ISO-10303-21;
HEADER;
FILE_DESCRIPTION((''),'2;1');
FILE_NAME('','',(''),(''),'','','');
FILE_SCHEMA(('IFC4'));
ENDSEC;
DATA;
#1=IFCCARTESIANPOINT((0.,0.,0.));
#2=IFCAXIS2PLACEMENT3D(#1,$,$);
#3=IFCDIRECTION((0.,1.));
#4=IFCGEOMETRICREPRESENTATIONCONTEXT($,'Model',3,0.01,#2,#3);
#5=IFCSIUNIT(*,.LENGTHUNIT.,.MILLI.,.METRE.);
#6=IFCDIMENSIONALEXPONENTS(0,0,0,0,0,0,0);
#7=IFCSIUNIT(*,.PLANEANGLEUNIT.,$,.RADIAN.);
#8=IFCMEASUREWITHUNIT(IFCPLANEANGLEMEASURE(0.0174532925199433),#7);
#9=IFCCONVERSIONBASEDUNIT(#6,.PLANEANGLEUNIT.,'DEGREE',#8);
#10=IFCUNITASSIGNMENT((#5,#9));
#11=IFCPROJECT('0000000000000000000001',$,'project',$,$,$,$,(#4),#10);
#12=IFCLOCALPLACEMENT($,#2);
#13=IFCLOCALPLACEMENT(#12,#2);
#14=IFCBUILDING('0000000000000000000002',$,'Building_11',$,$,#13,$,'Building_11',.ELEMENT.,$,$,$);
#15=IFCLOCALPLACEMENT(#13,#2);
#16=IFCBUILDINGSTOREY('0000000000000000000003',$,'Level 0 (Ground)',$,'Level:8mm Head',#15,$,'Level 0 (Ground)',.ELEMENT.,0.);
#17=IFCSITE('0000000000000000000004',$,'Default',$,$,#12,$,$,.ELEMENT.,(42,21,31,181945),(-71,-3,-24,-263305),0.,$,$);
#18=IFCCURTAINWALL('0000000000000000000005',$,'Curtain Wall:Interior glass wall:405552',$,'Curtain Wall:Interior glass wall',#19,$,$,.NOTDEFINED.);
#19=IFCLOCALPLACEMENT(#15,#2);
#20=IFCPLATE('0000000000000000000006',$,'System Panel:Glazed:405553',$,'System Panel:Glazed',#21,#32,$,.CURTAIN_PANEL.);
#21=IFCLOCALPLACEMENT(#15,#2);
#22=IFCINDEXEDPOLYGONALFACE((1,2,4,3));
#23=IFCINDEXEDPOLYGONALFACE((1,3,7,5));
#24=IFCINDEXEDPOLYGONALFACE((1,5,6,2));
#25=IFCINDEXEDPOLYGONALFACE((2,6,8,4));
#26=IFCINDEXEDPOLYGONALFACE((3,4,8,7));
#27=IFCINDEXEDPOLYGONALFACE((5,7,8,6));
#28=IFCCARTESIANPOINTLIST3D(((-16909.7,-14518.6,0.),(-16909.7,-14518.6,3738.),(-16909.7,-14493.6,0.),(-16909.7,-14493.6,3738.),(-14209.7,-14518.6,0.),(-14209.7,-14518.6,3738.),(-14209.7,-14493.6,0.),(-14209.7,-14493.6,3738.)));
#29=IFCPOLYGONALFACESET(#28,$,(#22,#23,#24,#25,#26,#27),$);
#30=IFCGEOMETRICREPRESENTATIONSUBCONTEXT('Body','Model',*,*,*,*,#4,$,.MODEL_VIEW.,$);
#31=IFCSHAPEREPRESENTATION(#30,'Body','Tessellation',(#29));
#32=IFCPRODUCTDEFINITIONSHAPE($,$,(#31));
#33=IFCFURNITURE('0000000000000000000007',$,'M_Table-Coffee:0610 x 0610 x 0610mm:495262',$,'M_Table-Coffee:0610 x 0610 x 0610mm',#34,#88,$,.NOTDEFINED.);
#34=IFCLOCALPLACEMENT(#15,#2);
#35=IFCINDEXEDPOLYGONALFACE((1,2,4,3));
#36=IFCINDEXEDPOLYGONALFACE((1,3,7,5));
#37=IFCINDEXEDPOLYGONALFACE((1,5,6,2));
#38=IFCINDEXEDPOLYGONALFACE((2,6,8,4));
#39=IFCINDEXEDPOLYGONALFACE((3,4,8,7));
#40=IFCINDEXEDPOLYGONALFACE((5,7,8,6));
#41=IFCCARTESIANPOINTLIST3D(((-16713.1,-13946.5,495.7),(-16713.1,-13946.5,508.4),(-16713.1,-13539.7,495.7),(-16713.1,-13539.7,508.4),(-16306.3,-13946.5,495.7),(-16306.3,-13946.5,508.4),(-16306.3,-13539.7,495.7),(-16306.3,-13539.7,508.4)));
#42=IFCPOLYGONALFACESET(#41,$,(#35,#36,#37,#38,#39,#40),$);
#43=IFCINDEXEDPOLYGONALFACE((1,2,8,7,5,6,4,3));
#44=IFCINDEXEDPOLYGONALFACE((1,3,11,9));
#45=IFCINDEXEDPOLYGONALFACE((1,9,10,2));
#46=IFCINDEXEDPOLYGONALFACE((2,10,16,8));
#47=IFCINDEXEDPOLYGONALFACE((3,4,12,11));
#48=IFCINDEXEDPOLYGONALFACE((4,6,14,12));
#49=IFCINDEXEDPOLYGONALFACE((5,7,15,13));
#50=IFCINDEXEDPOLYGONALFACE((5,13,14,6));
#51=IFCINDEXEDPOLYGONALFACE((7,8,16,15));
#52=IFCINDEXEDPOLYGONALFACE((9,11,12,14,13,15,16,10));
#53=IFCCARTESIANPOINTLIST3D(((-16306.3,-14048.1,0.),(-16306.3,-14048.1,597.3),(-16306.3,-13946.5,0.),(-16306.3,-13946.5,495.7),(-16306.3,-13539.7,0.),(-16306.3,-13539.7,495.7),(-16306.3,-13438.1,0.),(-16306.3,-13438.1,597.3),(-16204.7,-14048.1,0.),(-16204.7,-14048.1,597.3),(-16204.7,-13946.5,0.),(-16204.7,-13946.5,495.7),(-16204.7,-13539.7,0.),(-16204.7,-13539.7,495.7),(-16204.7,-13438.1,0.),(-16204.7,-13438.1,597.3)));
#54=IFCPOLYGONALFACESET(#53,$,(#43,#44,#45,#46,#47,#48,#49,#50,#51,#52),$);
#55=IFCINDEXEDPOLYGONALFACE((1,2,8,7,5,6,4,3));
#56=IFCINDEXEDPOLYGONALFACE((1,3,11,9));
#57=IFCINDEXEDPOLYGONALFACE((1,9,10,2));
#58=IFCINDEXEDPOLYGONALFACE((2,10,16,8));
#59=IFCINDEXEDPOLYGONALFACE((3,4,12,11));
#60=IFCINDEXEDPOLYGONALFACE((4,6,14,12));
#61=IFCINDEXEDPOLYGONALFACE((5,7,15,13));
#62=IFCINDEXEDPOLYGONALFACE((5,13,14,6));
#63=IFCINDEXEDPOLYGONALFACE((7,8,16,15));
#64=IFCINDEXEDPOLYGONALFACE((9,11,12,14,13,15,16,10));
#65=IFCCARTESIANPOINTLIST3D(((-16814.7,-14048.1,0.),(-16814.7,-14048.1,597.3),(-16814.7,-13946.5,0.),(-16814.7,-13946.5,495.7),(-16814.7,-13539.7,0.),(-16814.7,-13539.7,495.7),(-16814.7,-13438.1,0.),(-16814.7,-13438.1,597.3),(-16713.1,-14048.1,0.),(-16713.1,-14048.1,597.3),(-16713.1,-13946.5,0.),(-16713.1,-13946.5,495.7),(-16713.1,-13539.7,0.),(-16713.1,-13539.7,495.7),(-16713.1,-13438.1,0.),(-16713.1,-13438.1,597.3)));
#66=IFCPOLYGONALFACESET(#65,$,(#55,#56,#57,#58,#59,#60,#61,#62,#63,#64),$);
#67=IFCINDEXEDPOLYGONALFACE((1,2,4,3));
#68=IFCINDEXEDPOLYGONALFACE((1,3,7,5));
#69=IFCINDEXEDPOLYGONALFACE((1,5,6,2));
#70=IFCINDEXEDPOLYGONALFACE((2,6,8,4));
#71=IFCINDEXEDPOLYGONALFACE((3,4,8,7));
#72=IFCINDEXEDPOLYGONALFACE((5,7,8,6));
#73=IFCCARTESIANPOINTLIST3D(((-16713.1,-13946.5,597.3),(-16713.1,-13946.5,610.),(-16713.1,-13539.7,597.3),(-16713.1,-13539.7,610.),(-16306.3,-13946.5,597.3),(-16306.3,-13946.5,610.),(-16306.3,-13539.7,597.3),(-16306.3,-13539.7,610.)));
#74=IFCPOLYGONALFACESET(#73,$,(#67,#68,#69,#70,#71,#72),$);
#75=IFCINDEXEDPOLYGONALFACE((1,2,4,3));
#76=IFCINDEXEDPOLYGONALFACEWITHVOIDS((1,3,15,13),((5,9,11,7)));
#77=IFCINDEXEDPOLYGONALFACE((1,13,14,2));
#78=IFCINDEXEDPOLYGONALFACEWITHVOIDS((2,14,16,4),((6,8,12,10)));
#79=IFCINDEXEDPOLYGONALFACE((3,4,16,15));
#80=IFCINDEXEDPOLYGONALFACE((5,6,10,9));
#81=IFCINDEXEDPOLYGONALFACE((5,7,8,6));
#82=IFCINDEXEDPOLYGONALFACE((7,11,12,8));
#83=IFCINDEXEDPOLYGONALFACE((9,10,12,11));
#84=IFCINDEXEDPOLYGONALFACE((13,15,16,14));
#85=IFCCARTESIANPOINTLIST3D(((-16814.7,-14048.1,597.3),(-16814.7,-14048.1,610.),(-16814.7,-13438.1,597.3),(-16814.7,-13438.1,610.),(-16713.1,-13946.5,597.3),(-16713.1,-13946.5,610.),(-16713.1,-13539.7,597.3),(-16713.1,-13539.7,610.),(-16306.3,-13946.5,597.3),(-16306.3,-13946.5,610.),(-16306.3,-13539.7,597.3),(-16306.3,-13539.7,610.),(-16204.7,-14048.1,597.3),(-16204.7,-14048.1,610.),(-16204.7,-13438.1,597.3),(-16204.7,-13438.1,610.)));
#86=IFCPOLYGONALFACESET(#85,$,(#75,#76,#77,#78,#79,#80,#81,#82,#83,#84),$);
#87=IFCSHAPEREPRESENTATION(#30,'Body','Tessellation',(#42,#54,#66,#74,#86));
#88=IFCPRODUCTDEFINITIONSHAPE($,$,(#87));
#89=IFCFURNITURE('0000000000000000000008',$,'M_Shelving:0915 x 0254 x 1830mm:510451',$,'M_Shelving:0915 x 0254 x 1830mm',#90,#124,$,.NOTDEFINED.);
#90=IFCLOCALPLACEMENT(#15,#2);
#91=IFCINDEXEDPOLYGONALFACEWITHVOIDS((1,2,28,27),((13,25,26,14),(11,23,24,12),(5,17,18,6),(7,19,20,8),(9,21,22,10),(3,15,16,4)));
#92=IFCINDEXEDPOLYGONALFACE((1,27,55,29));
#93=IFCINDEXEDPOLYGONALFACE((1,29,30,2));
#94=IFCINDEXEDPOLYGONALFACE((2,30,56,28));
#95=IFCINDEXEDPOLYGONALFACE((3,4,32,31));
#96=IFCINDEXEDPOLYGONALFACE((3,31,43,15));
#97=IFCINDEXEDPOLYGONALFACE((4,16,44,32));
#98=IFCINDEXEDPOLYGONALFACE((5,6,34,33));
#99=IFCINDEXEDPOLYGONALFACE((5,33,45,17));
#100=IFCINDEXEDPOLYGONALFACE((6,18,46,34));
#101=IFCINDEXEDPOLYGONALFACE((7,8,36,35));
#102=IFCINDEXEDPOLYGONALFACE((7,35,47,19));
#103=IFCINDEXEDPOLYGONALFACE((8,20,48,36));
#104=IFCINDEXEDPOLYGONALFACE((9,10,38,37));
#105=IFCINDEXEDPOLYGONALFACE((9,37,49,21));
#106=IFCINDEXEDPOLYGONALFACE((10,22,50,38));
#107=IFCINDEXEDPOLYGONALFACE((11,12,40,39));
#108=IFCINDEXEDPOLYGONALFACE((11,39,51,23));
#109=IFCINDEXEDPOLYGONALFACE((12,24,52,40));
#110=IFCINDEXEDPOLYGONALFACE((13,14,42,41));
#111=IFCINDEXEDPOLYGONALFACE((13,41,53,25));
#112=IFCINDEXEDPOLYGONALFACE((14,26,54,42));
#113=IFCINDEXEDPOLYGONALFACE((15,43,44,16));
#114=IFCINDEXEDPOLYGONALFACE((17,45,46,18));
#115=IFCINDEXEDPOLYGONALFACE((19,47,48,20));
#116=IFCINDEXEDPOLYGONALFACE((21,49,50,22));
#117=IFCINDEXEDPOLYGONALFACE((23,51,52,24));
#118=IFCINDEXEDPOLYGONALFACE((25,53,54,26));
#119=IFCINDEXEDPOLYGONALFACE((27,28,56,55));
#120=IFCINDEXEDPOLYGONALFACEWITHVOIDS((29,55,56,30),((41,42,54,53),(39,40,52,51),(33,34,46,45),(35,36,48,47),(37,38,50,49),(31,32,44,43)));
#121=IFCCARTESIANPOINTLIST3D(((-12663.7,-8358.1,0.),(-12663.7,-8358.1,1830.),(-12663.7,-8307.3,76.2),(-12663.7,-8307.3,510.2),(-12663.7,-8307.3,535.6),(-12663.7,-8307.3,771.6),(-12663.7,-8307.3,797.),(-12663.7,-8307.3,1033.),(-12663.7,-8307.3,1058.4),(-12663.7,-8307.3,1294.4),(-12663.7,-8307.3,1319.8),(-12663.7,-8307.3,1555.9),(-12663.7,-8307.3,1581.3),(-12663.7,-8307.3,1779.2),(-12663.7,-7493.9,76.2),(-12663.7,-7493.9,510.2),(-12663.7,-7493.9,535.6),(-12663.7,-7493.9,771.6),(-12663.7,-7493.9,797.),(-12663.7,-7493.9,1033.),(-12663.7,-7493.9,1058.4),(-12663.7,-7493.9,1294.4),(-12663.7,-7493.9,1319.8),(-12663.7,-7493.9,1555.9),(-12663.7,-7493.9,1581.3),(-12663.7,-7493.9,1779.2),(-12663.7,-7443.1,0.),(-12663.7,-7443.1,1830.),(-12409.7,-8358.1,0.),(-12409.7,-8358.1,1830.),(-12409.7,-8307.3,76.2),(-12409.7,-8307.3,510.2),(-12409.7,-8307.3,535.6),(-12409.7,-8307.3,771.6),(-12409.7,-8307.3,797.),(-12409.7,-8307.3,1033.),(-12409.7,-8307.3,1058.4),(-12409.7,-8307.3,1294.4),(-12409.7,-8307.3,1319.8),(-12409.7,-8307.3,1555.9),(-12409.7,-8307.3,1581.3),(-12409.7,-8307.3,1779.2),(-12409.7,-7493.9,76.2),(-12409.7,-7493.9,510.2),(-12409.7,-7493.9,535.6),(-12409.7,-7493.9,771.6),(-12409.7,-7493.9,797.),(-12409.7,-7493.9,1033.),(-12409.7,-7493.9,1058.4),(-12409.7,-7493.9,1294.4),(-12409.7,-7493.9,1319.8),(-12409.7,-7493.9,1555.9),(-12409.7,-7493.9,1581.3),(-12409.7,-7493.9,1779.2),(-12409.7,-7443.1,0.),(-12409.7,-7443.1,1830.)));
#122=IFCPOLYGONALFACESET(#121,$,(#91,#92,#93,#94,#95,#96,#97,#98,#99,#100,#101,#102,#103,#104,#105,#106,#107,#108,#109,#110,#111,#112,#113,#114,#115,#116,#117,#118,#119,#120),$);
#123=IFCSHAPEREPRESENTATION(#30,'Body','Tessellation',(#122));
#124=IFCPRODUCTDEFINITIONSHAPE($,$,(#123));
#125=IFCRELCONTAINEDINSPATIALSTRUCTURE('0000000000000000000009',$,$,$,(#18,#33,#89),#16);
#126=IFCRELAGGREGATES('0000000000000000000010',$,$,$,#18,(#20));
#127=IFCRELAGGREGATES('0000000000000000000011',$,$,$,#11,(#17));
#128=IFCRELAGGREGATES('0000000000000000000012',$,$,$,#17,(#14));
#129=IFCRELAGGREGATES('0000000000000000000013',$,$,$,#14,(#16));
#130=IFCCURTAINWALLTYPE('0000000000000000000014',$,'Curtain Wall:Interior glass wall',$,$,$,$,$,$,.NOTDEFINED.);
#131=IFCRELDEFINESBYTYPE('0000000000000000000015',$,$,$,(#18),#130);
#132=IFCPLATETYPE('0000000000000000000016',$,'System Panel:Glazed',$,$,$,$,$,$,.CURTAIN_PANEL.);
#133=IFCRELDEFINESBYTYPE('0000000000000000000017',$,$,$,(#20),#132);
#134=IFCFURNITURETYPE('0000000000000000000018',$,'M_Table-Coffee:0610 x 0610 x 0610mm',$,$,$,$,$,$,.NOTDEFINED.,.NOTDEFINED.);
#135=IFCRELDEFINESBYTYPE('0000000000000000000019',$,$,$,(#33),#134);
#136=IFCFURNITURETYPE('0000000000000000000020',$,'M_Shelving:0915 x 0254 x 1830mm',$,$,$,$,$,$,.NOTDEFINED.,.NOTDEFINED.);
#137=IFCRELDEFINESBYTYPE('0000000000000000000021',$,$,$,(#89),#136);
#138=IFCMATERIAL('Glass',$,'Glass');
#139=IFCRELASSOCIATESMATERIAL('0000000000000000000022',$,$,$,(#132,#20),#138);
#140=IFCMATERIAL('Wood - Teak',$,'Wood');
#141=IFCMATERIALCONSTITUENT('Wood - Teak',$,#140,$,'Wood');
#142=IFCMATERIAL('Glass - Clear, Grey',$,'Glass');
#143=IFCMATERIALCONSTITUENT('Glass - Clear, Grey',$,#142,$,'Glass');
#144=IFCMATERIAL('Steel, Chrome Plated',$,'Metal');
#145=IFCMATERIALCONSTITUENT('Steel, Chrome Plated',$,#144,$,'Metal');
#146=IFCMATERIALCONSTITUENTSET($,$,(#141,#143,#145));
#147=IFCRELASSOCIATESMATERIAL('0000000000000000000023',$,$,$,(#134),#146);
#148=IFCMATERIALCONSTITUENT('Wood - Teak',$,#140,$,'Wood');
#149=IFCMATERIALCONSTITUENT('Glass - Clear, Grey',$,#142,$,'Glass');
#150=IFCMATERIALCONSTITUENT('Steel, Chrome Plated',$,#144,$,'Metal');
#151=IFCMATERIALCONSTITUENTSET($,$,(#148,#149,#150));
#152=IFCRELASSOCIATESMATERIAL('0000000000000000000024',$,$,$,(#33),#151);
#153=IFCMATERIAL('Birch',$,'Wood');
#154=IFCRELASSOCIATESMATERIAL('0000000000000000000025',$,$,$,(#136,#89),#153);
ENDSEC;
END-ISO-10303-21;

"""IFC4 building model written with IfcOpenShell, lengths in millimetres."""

from ifc_helpers import new_model, entity, si_unit, converted_unit, direction, frame, origin, place, context, subcontext, project, spatial, indexed_curve, outline, extrude, source, transform, mapped, material, constituent, constituent_set, type_object, type_shapes, element, aggregate, save


model = new_model("IFC4")

# Units and contexts
model_context = context("Model", 3, precision=0.01, world=origin(), true_north=direction((0.0, 1.0)))
body_context = subcontext(model_context, "Body", "Model", "MODEL_VIEW")
ifc_project = project(units=[si_unit("LENGTHUNIT", "METRE", prefix="MILLI"), converted_unit("PLANEANGLEUNIT", "DEGREE", entity("IfcPlaneAngleMeasure", 0.0174532925199433), si_unit("PLANEANGLEUNIT", "RADIAN"), dimensions=[0, 0, 0, 0, 0, 0, 0])], contexts=[model_context])

# Site, building, storey
site_placement = place(None, origin())
site = spatial("IfcSite", under=ifc_project, at=site_placement, Name="Default", CompositionType="ELEMENT", RefLatitude=(42, 21, 31, 181945), RefLongitude=(-71, -3, -24, -263305), RefElevation=0.0)
building_placement = place(site_placement, origin())
building = spatial("IfcBuilding", under=site, at=building_placement, Name="Building_11", LongName="Building_11", CompositionType="ELEMENT")
storey_placement = place(building_placement, origin())
storey = spatial("IfcBuildingStorey", under=building, at=storey_placement, Name="Level 0 (Ground)", ObjectType="Level:8mm Head", LongName="Level 0 (Ground)", CompositionType="ELEMENT", Elevation=0.0)

# Curtain wall, plate
curtain_wall_type = type_object("IfcCurtainWallType", Name="Curtain Wall:Interior glass wall", PredefinedType="NOTDEFINED")
curtain_wall_placement = place(storey_placement, origin())
curtain_wall = element("IfcCurtainWall", 1, at=curtain_wall_placement, inside=storey, type_object=curtain_wall_type, Name="Curtain Wall:Interior glass wall:405552", ObjectType="Curtain Wall:Interior glass wall", PredefinedType="NOTDEFINED")
ifc_material_1 = material(Name="Glass", Category="Glass")
plate_type = type_object("IfcPlateType", Name="System Panel:Glazed", PredefinedType="CURTAIN_PANEL", material=ifc_material_1)
shared_shape_1 = source(origin(), body_context, "Body", "SweptSolid", [
    extrude(outline(indexed_curve([(-12.5, -1350.0), (12.5, -1350.0), (12.5, 1350.0), (-12.5, 1350.0), (-12.5, -1350.0)], self_intersect=False)), frame((0.0, 37.0, 0.0), z_axis=(0.0, 0.0, 1.0), x_axis=(0.0, 1.0, 0.0)), (0.0, 0.0, 1.0), 3738.0),
])
type_shapes(plate_type, [shared_shape_1])
plate_placement = place(curtain_wall_placement, frame((-15559.7, -14543.1, 0.0)))
plate = element("IfcPlate", 2, at=plate_placement, type_object=plate_type, material=ifc_material_1, Name="System Panel:Glazed:405553", ObjectType="System Panel:Glazed", PredefinedType="CURTAIN_PANEL", context=body_context, shape_type="MappedRepresentation", body=[
    mapped(shared_shape_1, transform((0.0, 0.0, 0.0), scale=1.0)),
])
aggregate(curtain_wall, [plate])

# Furniture
ifc_material_2 = material(Name="Wood - Teak", Category="Wood")
ifc_constituent_1 = constituent(ifc_material_2, Name="Wood - Teak", Category="Wood")
ifc_material_3 = material(Name="Glass - Clear, Grey", Category="Glass")
ifc_constituent_2 = constituent(ifc_material_3, Name="Glass - Clear, Grey", Category="Glass")
ifc_material_4 = material(Name="Steel, Chrome Plated", Category="Metal")
ifc_constituent_3 = constituent(ifc_material_4, Name="Steel, Chrome Plated", Category="Metal")
ifc_constituent_set_1 = constituent_set(constituents=[ifc_constituent_1, ifc_constituent_2, ifc_constituent_3])
ifc_constituent_4 = constituent(ifc_material_2, Name="Wood - Teak", Category="Wood")
ifc_constituent_5 = constituent(ifc_material_3, Name="Glass - Clear, Grey", Category="Glass")
ifc_constituent_6 = constituent(ifc_material_4, Name="Steel, Chrome Plated", Category="Metal")
ifc_constituent_set_2 = constituent_set(constituents=[ifc_constituent_4, ifc_constituent_5, ifc_constituent_6])
furniture_type_1 = type_object("IfcFurnitureType", Name="M_Table-Coffee:0610 x 0610 x 0610mm", AssemblyPlace="NOTDEFINED", PredefinedType="NOTDEFINED", material=ifc_constituent_set_2)
shared_shape_2 = source(origin(), body_context, "Body", "SweptSolid", [
    extrude(outline(indexed_curve([(-203.4, -203.4), (203.4, -203.4), (203.4, 203.4), (-203.4, 203.4), (-203.4, -203.4)], self_intersect=False)), frame((18.3, 95.2, 495.7), z_axis=(0.0, 0.0, 1.0), x_axis=(-1.0, 0.0, 0.0)), (0.0, 0.0, 1.0), 12.7),
    extrude(outline(indexed_curve([(-273.2, -305.0), (324.0, -305.0), (324.0, 305.0), (-273.2, 305.0), (-273.2, 203.4), (222.5, 203.4), (222.5, -203.4), (-273.2, -203.4), (-273.2, -305.0)], self_intersect=False)), frame((221.7, 95.2, 273.2), z_axis=(1.0, 0.0, 0.0), x_axis=(0.0, 0.0, 1.0)), (0.0, 0.0, 1.0), 101.6),
    extrude(outline(indexed_curve([(-305.0, -324.1), (305.0, -324.1), (305.0, 273.3), (203.4, 273.3), (203.4, -222.4), (-203.4, -222.4), (-203.4, 273.3), (-305.0, 273.3), (-305.0, -324.1)], self_intersect=False)), frame((-286.7, 95.2, 273.3), z_axis=(1.0, 0.0, 0.0), x_axis=(0.0, -1.0, 0.0)), (0.0, 0.0, 1.0), 101.6),
    extrude(outline(indexed_curve([(-203.4, -203.4), (203.4, -203.4), (203.4, 203.4), (-203.4, 203.4), (-203.4, -203.4)], self_intersect=False)), frame((18.3, 95.2, 597.3), z_axis=(0.0, 0.0, 1.0), x_axis=(-1.0, 0.0, 0.0)), (0.0, 0.0, 1.0), 12.7),
    extrude(outline(indexed_curve([(-305.0, -305.0), (305.0, -305.0), (305.0, 305.0), (-305.0, 305.0), (-305.0, -305.0)], self_intersect=False), holes=[indexed_curve([(-203.4, -203.4), (-203.4, 203.4), (203.4, 203.4), (203.4, -203.4), (-203.4, -203.4)], self_intersect=False)]), frame((18.3, 95.2, 597.3), z_axis=(0.0, 0.0, 1.0), x_axis=(-1.0, 0.0, 0.0)), (0.0, 0.0, 1.0), 12.7),
])
type_shapes(furniture_type_1, [shared_shape_2])
furniture_1_placement = place(storey_placement, frame((-16528.0, -13838.3, 0.0)))
element("IfcFurniture", 3, at=furniture_1_placement, inside=storey, type_object=furniture_type_1, material=ifc_constituent_set_1, Name="M_Table-Coffee:0610 x 0610 x 0610mm:495262", ObjectType="M_Table-Coffee:0610 x 0610 x 0610mm", PredefinedType="NOTDEFINED", context=body_context, shape_type="MappedRepresentation", body=[
    mapped(shared_shape_2, transform((0.0, 0.0, 0.0), scale=1.0)),
])
ifc_material_5 = material(Name="Birch", Category="Wood")
furniture_type_2 = type_object("IfcFurnitureType", Name="M_Shelving:0915 x 0254 x 1830mm", AssemblyPlace="NOTDEFINED", PredefinedType="NOTDEFINED", material=ifc_material_5)
shared_shape_3 = source(origin(), body_context, "Body", "SweptSolid", [
    extrude(outline(indexed_curve([(-457.5, -915.0), (457.5, -915.0), (457.5, 915.0), (-457.5, 915.0), (-457.5, -915.0)], self_intersect=False), holes=[indexed_curve([(-406.7, 864.2), (406.7, 864.2), (406.7, 666.3), (-406.7, 666.3), (-406.7, 864.2)], self_intersect=False), indexed_curve([(-406.7, -838.8), (-406.7, -404.8), (406.7, -404.8), (406.7, -838.8), (-406.7, -838.8)], self_intersect=False), indexed_curve([(406.7, 143.4), (-406.7, 143.4), (-406.7, 379.4), (406.7, 379.4), (406.7, 143.4)], self_intersect=False), indexed_curve([(-406.7, 640.9), (406.7, 640.9), (406.7, 404.8), (-406.7, 404.8), (-406.7, 640.9)], self_intersect=False), indexed_curve([(-406.7, 118.0), (406.7, 118.0), (406.7, -118.0), (-406.7, -118.0), (-406.7, 118.0)], self_intersect=False), indexed_curve([(-406.7, -143.4), (406.7, -143.4), (406.7, -379.4), (-406.7, -379.4), (-406.7, -143.4)], self_intersect=False)]), frame((0.0, -431.8, 915.0), z_axis=(0.0, 1.0, 0.0), x_axis=(-1.0, 0.0, 0.0)), (0.0, 0.0, 1.0), 254.0),
])
type_shapes(furniture_type_2, [shared_shape_3])
furniture_2_placement = place(storey_placement, frame((-12841.5, -7900.6, 0.0), z_axis=(0.0, 0.0, 1.0), x_axis=(0.0, 1.0, 0.0)))
element("IfcFurniture", 4, at=furniture_2_placement, inside=storey, type_object=furniture_type_2, material=ifc_material_5, Name="M_Shelving:0915 x 0254 x 1830mm:510451", ObjectType="M_Shelving:0915 x 0254 x 1830mm", PredefinedType="NOTDEFINED", context=body_context, shape_type="MappedRepresentation", body=[
    mapped(shared_shape_3, transform((0.0, 0.0, 0.0), scale=1.0)),
])

save(model, "model.ifc")
